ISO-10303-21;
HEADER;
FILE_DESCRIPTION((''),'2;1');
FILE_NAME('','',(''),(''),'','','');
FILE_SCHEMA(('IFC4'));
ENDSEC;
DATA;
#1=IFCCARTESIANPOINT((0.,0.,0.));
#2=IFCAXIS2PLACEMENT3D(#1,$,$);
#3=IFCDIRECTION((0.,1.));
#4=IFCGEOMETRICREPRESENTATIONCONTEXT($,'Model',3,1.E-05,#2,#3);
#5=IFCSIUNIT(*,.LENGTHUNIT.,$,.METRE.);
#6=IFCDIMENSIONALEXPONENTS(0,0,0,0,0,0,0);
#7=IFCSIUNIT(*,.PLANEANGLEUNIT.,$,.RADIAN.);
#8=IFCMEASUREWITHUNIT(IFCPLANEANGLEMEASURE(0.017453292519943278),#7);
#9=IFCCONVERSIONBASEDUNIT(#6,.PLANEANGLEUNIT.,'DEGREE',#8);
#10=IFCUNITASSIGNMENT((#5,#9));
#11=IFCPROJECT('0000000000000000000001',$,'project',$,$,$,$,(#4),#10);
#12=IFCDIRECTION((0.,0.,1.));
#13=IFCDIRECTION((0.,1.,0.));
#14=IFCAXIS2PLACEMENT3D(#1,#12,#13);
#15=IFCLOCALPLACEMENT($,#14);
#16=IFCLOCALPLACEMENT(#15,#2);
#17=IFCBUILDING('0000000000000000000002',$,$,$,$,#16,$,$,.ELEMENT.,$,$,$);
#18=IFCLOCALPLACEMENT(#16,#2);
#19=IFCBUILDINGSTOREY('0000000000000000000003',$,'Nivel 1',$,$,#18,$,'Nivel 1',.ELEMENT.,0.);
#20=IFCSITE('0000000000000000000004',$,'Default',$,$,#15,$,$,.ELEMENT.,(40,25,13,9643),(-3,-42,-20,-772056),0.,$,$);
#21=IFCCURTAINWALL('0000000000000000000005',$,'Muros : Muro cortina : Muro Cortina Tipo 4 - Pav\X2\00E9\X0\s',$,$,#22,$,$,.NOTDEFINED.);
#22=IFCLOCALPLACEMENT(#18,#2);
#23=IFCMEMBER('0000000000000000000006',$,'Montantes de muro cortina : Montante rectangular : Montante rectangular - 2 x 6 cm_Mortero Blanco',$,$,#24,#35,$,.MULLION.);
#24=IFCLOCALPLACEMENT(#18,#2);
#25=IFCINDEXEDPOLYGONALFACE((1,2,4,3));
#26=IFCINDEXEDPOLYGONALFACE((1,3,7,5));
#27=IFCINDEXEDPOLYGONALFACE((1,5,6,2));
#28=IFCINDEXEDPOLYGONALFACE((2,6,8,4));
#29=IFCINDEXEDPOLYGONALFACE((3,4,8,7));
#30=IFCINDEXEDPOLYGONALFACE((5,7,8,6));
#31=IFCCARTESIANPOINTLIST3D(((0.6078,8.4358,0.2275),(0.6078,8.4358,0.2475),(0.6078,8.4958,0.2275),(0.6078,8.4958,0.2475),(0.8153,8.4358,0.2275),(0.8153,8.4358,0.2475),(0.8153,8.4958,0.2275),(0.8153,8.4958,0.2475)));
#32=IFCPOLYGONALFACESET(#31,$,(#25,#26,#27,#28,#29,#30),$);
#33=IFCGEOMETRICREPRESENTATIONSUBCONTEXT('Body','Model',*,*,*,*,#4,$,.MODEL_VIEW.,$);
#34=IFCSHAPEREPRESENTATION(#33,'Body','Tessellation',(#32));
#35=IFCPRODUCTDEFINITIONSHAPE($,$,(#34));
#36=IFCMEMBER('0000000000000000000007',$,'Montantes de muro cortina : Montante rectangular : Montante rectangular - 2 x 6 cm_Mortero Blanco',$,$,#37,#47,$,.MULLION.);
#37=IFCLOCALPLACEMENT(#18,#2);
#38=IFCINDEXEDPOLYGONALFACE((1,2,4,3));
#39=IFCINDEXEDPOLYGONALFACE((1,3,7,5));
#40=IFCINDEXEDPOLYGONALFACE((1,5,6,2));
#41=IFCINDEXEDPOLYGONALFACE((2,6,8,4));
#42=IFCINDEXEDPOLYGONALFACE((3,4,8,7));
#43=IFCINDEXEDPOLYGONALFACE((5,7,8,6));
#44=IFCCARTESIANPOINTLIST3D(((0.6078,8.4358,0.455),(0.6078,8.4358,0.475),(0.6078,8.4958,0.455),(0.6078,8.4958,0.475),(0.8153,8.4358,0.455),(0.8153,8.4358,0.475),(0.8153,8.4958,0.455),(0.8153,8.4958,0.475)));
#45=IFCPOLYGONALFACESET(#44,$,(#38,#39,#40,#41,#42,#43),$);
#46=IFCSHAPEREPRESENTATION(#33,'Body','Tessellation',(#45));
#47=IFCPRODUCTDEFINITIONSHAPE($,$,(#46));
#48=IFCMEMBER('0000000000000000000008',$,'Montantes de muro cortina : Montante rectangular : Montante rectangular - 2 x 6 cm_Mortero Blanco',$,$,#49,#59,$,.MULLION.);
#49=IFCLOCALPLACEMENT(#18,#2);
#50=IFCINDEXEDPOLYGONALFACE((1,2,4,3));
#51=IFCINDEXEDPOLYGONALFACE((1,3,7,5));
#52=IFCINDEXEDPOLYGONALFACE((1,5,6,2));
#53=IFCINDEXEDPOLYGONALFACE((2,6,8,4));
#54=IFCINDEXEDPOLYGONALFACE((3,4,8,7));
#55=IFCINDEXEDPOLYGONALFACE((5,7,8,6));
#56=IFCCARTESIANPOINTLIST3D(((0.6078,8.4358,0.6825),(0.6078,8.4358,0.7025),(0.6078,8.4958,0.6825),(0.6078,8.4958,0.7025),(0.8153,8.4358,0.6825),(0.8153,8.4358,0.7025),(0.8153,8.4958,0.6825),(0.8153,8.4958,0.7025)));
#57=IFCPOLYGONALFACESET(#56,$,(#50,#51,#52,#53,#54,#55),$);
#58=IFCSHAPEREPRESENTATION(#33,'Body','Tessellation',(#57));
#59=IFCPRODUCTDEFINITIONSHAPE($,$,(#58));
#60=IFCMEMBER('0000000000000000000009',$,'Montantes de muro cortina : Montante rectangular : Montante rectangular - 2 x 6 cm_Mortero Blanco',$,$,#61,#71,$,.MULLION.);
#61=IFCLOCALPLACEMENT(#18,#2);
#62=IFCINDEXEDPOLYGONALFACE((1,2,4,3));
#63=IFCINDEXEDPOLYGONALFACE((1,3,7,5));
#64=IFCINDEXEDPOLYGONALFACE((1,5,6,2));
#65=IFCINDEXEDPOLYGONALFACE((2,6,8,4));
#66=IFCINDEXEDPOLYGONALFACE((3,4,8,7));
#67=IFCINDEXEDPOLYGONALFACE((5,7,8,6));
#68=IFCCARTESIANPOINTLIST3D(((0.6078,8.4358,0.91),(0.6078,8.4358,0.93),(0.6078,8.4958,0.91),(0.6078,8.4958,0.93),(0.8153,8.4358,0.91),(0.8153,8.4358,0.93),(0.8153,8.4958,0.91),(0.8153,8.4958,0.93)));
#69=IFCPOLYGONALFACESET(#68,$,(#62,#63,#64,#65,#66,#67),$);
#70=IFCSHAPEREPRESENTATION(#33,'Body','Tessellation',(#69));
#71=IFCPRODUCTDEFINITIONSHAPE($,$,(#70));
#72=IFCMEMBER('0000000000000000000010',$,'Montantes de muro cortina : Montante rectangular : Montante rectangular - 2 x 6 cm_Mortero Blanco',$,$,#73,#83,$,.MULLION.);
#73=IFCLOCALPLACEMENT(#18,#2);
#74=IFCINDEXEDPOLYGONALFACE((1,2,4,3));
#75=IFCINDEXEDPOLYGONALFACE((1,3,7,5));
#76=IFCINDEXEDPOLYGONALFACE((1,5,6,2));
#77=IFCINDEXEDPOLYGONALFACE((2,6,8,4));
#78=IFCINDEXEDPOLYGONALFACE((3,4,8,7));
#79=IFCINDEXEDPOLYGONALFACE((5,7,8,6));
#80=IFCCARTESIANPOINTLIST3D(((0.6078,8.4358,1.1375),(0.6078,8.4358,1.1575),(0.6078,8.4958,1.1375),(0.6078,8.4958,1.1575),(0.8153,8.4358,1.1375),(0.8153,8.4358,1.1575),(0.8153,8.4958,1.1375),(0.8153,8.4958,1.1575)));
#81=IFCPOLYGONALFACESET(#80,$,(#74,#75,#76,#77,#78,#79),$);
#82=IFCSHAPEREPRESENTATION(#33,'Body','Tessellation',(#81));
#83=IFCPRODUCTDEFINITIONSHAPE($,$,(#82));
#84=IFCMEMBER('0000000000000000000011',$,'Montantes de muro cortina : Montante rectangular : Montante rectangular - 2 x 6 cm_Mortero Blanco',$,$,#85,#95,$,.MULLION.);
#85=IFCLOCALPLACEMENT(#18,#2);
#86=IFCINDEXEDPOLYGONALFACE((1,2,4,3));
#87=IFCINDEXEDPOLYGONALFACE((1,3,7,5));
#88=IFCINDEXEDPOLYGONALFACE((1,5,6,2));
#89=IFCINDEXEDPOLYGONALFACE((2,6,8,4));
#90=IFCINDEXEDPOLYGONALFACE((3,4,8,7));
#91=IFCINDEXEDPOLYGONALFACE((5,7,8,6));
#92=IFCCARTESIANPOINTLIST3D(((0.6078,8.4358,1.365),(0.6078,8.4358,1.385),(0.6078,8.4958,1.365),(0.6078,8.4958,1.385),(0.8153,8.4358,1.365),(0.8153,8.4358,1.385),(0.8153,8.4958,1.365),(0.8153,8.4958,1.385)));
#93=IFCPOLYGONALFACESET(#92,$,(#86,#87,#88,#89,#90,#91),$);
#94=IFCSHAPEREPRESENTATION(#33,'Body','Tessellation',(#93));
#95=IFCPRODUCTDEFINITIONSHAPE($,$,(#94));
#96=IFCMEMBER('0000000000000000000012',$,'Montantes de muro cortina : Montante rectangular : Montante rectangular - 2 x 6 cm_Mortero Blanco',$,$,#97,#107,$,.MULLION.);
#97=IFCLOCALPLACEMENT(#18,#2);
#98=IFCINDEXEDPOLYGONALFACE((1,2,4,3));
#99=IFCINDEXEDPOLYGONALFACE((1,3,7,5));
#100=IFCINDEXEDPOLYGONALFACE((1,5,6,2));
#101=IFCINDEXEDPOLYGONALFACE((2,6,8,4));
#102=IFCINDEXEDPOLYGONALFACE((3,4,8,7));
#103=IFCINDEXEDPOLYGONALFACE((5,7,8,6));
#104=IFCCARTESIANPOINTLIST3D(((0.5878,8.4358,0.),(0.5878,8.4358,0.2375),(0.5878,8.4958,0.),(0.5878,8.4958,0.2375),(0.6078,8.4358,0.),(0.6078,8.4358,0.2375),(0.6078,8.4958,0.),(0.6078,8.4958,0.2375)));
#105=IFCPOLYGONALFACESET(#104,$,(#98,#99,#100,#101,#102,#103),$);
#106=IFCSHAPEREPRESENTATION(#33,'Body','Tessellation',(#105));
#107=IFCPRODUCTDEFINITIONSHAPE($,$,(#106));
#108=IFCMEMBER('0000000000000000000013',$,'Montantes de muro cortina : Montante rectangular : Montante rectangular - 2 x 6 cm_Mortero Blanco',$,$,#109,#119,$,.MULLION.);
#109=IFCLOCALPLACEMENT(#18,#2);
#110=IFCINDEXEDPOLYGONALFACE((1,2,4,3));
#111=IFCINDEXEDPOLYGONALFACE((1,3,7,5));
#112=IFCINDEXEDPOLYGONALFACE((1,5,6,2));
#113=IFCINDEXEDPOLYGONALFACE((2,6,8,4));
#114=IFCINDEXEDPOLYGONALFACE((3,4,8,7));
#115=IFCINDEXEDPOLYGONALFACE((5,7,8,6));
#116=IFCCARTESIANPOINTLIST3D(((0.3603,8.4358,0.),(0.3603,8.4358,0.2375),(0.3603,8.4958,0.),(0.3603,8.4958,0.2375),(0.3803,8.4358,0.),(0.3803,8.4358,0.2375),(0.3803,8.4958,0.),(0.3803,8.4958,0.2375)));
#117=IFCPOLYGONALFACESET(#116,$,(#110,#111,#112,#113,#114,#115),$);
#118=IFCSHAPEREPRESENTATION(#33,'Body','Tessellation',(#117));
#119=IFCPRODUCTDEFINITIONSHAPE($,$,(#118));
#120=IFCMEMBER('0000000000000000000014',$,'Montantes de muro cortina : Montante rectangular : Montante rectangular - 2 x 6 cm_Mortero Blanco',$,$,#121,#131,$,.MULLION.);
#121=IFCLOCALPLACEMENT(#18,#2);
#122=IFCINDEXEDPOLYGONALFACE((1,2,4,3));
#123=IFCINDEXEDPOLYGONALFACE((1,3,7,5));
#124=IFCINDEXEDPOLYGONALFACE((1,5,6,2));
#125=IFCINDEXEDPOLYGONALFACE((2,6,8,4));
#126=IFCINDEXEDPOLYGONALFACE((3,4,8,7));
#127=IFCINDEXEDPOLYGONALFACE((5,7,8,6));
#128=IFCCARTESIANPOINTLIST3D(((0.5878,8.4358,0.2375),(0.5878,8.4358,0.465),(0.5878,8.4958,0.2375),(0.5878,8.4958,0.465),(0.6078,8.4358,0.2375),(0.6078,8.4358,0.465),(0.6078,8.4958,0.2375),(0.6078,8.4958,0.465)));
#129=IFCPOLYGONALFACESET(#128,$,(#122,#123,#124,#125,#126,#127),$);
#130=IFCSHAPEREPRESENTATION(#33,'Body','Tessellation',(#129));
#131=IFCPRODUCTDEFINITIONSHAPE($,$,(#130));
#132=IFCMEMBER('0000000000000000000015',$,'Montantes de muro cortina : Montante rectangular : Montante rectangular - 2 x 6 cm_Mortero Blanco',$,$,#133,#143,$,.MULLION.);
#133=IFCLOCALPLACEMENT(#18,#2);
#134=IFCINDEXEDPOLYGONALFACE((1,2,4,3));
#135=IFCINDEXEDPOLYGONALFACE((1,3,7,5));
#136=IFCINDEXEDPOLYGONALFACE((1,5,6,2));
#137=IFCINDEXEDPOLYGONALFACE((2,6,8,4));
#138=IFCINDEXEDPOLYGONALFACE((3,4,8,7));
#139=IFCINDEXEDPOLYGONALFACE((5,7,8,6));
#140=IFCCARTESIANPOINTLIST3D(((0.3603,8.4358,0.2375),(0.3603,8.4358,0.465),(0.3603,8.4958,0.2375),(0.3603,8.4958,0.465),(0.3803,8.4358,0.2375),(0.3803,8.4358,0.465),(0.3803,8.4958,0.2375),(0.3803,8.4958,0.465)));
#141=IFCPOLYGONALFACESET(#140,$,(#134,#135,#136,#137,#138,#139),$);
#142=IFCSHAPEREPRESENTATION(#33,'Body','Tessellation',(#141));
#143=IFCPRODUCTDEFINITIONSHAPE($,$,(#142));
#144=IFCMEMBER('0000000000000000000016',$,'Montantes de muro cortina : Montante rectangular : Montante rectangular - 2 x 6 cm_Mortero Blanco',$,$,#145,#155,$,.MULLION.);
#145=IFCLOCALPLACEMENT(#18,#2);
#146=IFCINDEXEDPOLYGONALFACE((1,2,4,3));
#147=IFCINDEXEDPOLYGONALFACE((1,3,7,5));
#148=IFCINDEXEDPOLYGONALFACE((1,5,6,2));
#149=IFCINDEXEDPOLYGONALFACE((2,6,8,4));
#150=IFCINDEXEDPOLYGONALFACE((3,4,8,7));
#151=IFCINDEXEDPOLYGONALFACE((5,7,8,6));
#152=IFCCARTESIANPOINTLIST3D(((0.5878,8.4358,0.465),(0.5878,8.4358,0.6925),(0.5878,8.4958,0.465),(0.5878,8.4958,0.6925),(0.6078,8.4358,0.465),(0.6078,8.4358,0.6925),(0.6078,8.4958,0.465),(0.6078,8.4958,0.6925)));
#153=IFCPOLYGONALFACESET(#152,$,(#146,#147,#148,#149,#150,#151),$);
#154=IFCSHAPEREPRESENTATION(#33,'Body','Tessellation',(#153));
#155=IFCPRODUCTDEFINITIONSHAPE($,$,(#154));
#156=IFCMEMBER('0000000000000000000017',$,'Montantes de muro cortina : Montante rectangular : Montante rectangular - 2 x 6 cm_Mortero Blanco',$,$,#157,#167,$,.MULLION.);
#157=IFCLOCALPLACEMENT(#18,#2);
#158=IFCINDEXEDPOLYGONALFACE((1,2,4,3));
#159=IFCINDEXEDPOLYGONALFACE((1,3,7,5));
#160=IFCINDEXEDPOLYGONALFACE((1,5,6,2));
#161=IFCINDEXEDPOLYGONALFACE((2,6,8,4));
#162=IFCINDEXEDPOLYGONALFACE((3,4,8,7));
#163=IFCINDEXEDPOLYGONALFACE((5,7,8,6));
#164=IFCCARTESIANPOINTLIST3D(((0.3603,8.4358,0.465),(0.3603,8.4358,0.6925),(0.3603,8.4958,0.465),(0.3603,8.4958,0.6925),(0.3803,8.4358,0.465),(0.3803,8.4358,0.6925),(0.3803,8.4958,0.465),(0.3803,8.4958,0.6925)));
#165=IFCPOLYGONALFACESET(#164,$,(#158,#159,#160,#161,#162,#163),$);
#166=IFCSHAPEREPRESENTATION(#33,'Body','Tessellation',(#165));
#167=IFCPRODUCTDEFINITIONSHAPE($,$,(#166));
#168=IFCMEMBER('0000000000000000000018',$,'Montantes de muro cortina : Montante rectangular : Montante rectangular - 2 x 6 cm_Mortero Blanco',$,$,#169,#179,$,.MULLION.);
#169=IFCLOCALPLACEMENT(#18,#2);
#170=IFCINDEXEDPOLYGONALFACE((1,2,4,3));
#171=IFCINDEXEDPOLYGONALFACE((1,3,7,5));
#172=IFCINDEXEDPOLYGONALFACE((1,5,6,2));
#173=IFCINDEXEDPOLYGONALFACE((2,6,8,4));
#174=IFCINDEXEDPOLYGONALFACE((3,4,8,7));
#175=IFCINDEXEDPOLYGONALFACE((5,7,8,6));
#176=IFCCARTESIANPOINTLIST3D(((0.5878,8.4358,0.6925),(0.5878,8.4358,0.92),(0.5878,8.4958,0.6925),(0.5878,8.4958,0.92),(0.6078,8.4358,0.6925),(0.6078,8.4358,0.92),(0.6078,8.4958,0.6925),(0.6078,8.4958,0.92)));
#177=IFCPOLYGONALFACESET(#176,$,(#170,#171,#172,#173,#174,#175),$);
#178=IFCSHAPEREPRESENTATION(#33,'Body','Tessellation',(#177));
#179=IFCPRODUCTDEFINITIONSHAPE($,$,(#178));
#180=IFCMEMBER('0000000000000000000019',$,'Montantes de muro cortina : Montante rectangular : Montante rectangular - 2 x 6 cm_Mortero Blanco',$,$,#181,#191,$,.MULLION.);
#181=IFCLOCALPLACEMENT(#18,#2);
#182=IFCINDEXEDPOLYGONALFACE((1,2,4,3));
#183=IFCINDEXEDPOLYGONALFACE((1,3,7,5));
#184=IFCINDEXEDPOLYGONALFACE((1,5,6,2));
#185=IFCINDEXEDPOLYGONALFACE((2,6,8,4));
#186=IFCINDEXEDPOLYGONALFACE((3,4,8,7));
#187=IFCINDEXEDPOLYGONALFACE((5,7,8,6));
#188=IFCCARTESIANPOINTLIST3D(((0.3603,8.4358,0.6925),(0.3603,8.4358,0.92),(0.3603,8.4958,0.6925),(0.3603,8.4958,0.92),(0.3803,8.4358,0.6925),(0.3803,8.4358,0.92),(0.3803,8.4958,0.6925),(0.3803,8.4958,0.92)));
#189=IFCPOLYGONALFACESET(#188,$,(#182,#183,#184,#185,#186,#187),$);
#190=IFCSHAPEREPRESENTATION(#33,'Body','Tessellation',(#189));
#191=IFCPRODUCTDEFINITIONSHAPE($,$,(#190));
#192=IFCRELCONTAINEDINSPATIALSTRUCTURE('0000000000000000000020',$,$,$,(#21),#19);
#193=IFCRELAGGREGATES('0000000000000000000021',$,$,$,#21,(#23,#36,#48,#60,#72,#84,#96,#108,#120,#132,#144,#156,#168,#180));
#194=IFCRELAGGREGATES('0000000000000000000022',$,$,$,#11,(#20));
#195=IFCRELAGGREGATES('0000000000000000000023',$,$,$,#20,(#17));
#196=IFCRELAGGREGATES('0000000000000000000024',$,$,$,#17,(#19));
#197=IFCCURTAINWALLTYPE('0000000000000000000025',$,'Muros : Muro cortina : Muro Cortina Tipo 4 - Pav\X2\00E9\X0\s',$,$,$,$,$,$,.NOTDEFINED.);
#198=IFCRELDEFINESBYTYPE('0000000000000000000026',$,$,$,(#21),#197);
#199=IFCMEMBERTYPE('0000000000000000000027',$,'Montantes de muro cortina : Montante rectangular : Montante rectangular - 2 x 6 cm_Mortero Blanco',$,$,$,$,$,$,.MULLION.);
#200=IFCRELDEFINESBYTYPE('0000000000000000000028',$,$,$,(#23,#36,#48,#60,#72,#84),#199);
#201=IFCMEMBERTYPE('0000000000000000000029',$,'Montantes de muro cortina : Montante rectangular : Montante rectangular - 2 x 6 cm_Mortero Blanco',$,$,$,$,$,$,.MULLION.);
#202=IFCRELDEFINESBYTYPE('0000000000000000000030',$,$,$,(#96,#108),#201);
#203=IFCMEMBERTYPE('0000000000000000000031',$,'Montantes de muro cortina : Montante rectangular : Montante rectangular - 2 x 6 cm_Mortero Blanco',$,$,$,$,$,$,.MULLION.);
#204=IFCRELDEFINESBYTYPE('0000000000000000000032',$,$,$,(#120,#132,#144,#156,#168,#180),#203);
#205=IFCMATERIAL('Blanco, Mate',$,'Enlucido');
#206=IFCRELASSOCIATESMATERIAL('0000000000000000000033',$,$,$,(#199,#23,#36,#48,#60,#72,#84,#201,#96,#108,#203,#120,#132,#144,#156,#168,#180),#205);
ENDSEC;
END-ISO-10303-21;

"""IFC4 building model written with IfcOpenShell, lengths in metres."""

from ifc_helpers import new_model, entity, si_unit, converted_unit, direction, frame, origin, place, context, subcontext, project, spatial, indexed_curve, outline, extrude, source, transform, mapped, material, type_object, type_shapes, element, aggregate, save


model = new_model("IFC4")

# Units and contexts
model_context = context("Model", 3, precision=1e-05, world=origin(), true_north=direction((0.0, 1.0)))
body_context = subcontext(model_context, "Body", "Model", "MODEL_VIEW")
ifc_project = project(units=[si_unit("LENGTHUNIT", "METRE"), converted_unit("PLANEANGLEUNIT", "DEGREE", entity("IfcPlaneAngleMeasure", 0.017453292519943278), si_unit("PLANEANGLEUNIT", "RADIAN"), dimensions=[0, 0, 0, 0, 0, 0, 0])], contexts=[model_context])

# Site, building, storey
site_placement = place(None, frame((0.0, 0.0, 0.0), z_axis=(0.0, 0.0, 1.0), x_axis=(0.0, 1.0, 0.0)))
site = spatial("IfcSite", under=ifc_project, at=site_placement, Name="Default", CompositionType="ELEMENT", RefLatitude=(40, 25, 13, 9643), RefLongitude=(-3, -42, -20, -772056), RefElevation=0.0)
building_placement = place(site_placement, origin())
building = spatial("IfcBuilding", under=site, at=building_placement, CompositionType="ELEMENT")
storey_placement = place(building_placement, origin())
storey = spatial("IfcBuildingStorey", under=building, at=storey_placement, Name="Nivel 1", LongName="Nivel 1", CompositionType="ELEMENT", Elevation=0.0)

# Curtain wall, members
curtain_wall_type = type_object("IfcCurtainWallType", Name="Muros : Muro cortina : Muro Cortina Tipo 4 - Pavés", PredefinedType="NOTDEFINED")
curtain_wall_placement = place(storey_placement, origin())
curtain_wall = element("IfcCurtainWall", 1, at=curtain_wall_placement, inside=storey, type_object=curtain_wall_type, Name="Muros : Muro cortina : Muro Cortina Tipo 4 - Pavés", PredefinedType="NOTDEFINED")
ifc_material_1 = material(Name="Blanco, Mate", Category="Enlucido")
member_type_1 = type_object("IfcMemberType", Name="Montantes de muro cortina : Montante rectangular : Montante rectangular - 2 x 6 cm_Mortero Blanco", PredefinedType="MULLION", material=ifc_material_1)
shared_shape_1 = source(origin(), body_context, "Body", "SweptSolid", [
    extrude(outline(indexed_curve([(-0.01, -0.03), (0.01, -0.03), (0.01, 0.03), (-0.01, 0.03), (-0.01, -0.03)], self_intersect=False)), frame((0.0, 0.0, -0.2075), z_axis=(0.0, 0.0, 1.0), x_axis=(-1.0, 0.0, 0.0)), (0.0, 0.0, 1.0), 0.2075),
])
type_shapes(member_type_1, [shared_shape_1])
member_1_placement = place(curtain_wall_placement, frame((0.6078, 8.4658, 0.2375), z_axis=(-1.0, 0.0, 0.0), x_axis=(0.0, 0.0, 1.0)))
member_1 = element("IfcMember", 2, at=member_1_placement, type_object=member_type_1, material=ifc_material_1, Name="Montantes de muro cortina : Montante rectangular : Montante rectangular - 2 x 6 cm_Mortero Blanco", PredefinedType="MULLION", context=body_context, shape_type="MappedRepresentation", body=[
    mapped(shared_shape_1, transform((0.0, 0.0, 0.0), scale=1.0)),
])
member_2_placement = place(curtain_wall_placement, frame((0.6078, 8.4658, 0.465), z_axis=(-1.0, 0.0, 0.0), x_axis=(0.0, 0.0, 1.0)))
member_2 = element("IfcMember", 3, at=member_2_placement, type_object=member_type_1, material=ifc_material_1, Name="Montantes de muro cortina : Montante rectangular : Montante rectangular - 2 x 6 cm_Mortero Blanco", PredefinedType="MULLION", context=body_context, shape_type="MappedRepresentation", body=[
    mapped(shared_shape_1, transform((0.0, 0.0, 0.0), scale=1.0)),
])
member_3_placement = place(curtain_wall_placement, frame((0.6078, 8.4658, 0.6925), z_axis=(-1.0, 0.0, 0.0), x_axis=(0.0, 0.0, 1.0)))
member_3 = element("IfcMember", 4, at=member_3_placement, type_object=member_type_1, material=ifc_material_1, Name="Montantes de muro cortina : Montante rectangular : Montante rectangular - 2 x 6 cm_Mortero Blanco", PredefinedType="MULLION", context=body_context, shape_type="MappedRepresentation", body=[
    mapped(shared_shape_1, transform((0.0, 0.0, 0.0), scale=1.0)),
])
member_4_placement = place(curtain_wall_placement, frame((0.6078, 8.4658, 0.92), z_axis=(-1.0, 0.0, 0.0), x_axis=(0.0, 0.0, 1.0)))
member_4 = element("IfcMember", 5, at=member_4_placement, type_object=member_type_1, material=ifc_material_1, Name="Montantes de muro cortina : Montante rectangular : Montante rectangular - 2 x 6 cm_Mortero Blanco", PredefinedType="MULLION", context=body_context, shape_type="MappedRepresentation", body=[
    mapped(shared_shape_1, transform((0.0, 0.0, 0.0), scale=1.0)),
])
member_5_placement = place(curtain_wall_placement, frame((0.6078, 8.4658, 1.1475), z_axis=(-1.0, 0.0, 0.0), x_axis=(0.0, 0.0, 1.0)))
member_5 = element("IfcMember", 6, at=member_5_placement, type_object=member_type_1, material=ifc_material_1, Name="Montantes de muro cortina : Montante rectangular : Montante rectangular - 2 x 6 cm_Mortero Blanco", PredefinedType="MULLION", context=body_context, shape_type="MappedRepresentation", body=[
    mapped(shared_shape_1, transform((0.0, 0.0, 0.0), scale=1.0)),
])
member_6_placement = place(curtain_wall_placement, frame((0.6078, 8.4658, 1.375), z_axis=(-1.0, 0.0, 0.0), x_axis=(0.0, 0.0, 1.0)))
member_6 = element("IfcMember", 7, at=member_6_placement, type_object=member_type_1, material=ifc_material_1, Name="Montantes de muro cortina : Montante rectangular : Montante rectangular - 2 x 6 cm_Mortero Blanco", PredefinedType="MULLION", context=body_context, shape_type="MappedRepresentation", body=[
    mapped(shared_shape_1, transform((0.0, 0.0, 0.0), scale=1.0)),
])
member_type_2 = type_object("IfcMemberType", Name="Montantes de muro cortina : Montante rectangular : Montante rectangular - 2 x 6 cm_Mortero Blanco", PredefinedType="MULLION", material=ifc_material_1)
shared_shape_2 = source(origin(), body_context, "Body", "SweptSolid", [
    extrude(outline(indexed_curve([(-0.01, -0.03), (0.01, -0.03), (0.01, 0.03), (-0.01, 0.03), (-0.01, -0.03)], self_intersect=False)), frame((0.0, 0.0, -0.2375), z_axis=(0.0, 0.0, 1.0), x_axis=(-1.0, 0.0, 0.0)), (0.0, 0.0, 1.0), 0.2375),
])
type_shapes(member_type_2, [shared_shape_2])
member_7_placement = place(curtain_wall_placement, frame((0.5978, 8.4658, 0.0), z_axis=(0.0, 0.0, -1.0), x_axis=(-1.0, 0.0, 0.0)))
member_7 = element("IfcMember", 8, at=member_7_placement, type_object=member_type_2, material=ifc_material_1, Name="Montantes de muro cortina : Montante rectangular : Montante rectangular - 2 x 6 cm_Mortero Blanco", PredefinedType="MULLION", context=body_context, shape_type="MappedRepresentation", body=[
    mapped(shared_shape_2, transform((0.0, 0.0, 0.0), scale=1.0)),
])
member_8_placement = place(curtain_wall_placement, frame((0.3703, 8.4658, 0.0), z_axis=(0.0, 0.0, -1.0), x_axis=(-1.0, 0.0, 0.0)))
member_8 = element("IfcMember", 9, at=member_8_placement, type_object=member_type_2, material=ifc_material_1, Name="Montantes de muro cortina : Montante rectangular : Montante rectangular - 2 x 6 cm_Mortero Blanco", PredefinedType="MULLION", context=body_context, shape_type="MappedRepresentation", body=[
    mapped(shared_shape_2, transform((0.0, 0.0, 0.0), scale=1.0)),
])
member_type_3 = type_object("IfcMemberType", Name="Montantes de muro cortina : Montante rectangular : Montante rectangular - 2 x 6 cm_Mortero Blanco", PredefinedType="MULLION", material=ifc_material_1)
shared_shape_3 = source(origin(), body_context, "Body", "SweptSolid", [
    extrude(outline(indexed_curve([(-0.01, -0.03), (0.01, -0.03), (0.01, 0.03), (-0.01, 0.03), (-0.01, -0.03)], self_intersect=False)), frame((0.0, 0.0, -0.2275), z_axis=(0.0, 0.0, 1.0), x_axis=(-1.0, 0.0, 0.0)), (0.0, 0.0, 1.0), 0.2275),
])
type_shapes(member_type_3, [shared_shape_3])
member_9_placement = place(curtain_wall_placement, frame((0.5978, 8.4658, 0.2375), z_axis=(0.0, 0.0, -1.0), x_axis=(-1.0, 0.0, 0.0)))
member_9 = element("IfcMember", 10, at=member_9_placement, type_object=member_type_3, material=ifc_material_1, Name="Montantes de muro cortina : Montante rectangular : Montante rectangular - 2 x 6 cm_Mortero Blanco", PredefinedType="MULLION", context=body_context, shape_type="MappedRepresentation", body=[
    mapped(shared_shape_3, transform((0.0, 0.0, 0.0), scale=1.0)),
])
member_10_placement = place(curtain_wall_placement, frame((0.3703, 8.4658, 0.2375), z_axis=(0.0, 0.0, -1.0), x_axis=(-1.0, 0.0, 0.0)))
member_10 = element("IfcMember", 11, at=member_10_placement, type_object=member_type_3, material=ifc_material_1, Name="Montantes de muro cortina : Montante rectangular : Montante rectangular - 2 x 6 cm_Mortero Blanco", PredefinedType="MULLION", context=body_context, shape_type="MappedRepresentation", body=[
    mapped(shared_shape_3, transform((0.0, 0.0, 0.0), scale=1.0)),
])
member_11_placement = place(curtain_wall_placement, frame((0.5978, 8.4658, 0.465), z_axis=(0.0, 0.0, -1.0), x_axis=(-1.0, 0.0, 0.0)))
member_11 = element("IfcMember", 12, at=member_11_placement, type_object=member_type_3, material=ifc_material_1, Name="Montantes de muro cortina : Montante rectangular : Montante rectangular - 2 x 6 cm_Mortero Blanco", PredefinedType="MULLION", context=body_context, shape_type="MappedRepresentation", body=[
    mapped(shared_shape_3, transform((0.0, 0.0, 0.0), scale=1.0)),
])
member_12_placement = place(curtain_wall_placement, frame((0.3703, 8.4658, 0.465), z_axis=(0.0, 0.0, -1.0), x_axis=(-1.0, 0.0, 0.0)))
member_12 = element("IfcMember", 13, at=member_12_placement, type_object=member_type_3, material=ifc_material_1, Name="Montantes de muro cortina : Montante rectangular : Montante rectangular - 2 x 6 cm_Mortero Blanco", PredefinedType="MULLION", context=body_context, shape_type="MappedRepresentation", body=[
    mapped(shared_shape_3, transform((0.0, 0.0, 0.0), scale=1.0)),
])
member_13_placement = place(curtain_wall_placement, frame((0.5978, 8.4658, 0.6925), z_axis=(0.0, 0.0, -1.0), x_axis=(-1.0, 0.0, 0.0)))
member_13 = element("IfcMember", 14, at=member_13_placement, type_object=member_type_3, material=ifc_material_1, Name="Montantes de muro cortina : Montante rectangular : Montante rectangular - 2 x 6 cm_Mortero Blanco", PredefinedType="MULLION", context=body_context, shape_type="MappedRepresentation", body=[
    mapped(shared_shape_3, transform((0.0, 0.0, 0.0), scale=1.0)),
])
member_14_placement = place(curtain_wall_placement, frame((0.3703, 8.4658, 0.6925), z_axis=(0.0, 0.0, -1.0), x_axis=(-1.0, 0.0, 0.0)))
member_14 = element("IfcMember", 15, at=member_14_placement, type_object=member_type_3, material=ifc_material_1, Name="Montantes de muro cortina : Montante rectangular : Montante rectangular - 2 x 6 cm_Mortero Blanco", PredefinedType="MULLION", context=body_context, shape_type="MappedRepresentation", body=[
    mapped(shared_shape_3, transform((0.0, 0.0, 0.0), scale=1.0)),
])
aggregate(curtain_wall, [member_1, member_2, member_3, member_4, member_5, member_6, member_7, member_8, member_9, member_10, member_11, member_12, member_13, member_14])

save(model, "model.ifc")
